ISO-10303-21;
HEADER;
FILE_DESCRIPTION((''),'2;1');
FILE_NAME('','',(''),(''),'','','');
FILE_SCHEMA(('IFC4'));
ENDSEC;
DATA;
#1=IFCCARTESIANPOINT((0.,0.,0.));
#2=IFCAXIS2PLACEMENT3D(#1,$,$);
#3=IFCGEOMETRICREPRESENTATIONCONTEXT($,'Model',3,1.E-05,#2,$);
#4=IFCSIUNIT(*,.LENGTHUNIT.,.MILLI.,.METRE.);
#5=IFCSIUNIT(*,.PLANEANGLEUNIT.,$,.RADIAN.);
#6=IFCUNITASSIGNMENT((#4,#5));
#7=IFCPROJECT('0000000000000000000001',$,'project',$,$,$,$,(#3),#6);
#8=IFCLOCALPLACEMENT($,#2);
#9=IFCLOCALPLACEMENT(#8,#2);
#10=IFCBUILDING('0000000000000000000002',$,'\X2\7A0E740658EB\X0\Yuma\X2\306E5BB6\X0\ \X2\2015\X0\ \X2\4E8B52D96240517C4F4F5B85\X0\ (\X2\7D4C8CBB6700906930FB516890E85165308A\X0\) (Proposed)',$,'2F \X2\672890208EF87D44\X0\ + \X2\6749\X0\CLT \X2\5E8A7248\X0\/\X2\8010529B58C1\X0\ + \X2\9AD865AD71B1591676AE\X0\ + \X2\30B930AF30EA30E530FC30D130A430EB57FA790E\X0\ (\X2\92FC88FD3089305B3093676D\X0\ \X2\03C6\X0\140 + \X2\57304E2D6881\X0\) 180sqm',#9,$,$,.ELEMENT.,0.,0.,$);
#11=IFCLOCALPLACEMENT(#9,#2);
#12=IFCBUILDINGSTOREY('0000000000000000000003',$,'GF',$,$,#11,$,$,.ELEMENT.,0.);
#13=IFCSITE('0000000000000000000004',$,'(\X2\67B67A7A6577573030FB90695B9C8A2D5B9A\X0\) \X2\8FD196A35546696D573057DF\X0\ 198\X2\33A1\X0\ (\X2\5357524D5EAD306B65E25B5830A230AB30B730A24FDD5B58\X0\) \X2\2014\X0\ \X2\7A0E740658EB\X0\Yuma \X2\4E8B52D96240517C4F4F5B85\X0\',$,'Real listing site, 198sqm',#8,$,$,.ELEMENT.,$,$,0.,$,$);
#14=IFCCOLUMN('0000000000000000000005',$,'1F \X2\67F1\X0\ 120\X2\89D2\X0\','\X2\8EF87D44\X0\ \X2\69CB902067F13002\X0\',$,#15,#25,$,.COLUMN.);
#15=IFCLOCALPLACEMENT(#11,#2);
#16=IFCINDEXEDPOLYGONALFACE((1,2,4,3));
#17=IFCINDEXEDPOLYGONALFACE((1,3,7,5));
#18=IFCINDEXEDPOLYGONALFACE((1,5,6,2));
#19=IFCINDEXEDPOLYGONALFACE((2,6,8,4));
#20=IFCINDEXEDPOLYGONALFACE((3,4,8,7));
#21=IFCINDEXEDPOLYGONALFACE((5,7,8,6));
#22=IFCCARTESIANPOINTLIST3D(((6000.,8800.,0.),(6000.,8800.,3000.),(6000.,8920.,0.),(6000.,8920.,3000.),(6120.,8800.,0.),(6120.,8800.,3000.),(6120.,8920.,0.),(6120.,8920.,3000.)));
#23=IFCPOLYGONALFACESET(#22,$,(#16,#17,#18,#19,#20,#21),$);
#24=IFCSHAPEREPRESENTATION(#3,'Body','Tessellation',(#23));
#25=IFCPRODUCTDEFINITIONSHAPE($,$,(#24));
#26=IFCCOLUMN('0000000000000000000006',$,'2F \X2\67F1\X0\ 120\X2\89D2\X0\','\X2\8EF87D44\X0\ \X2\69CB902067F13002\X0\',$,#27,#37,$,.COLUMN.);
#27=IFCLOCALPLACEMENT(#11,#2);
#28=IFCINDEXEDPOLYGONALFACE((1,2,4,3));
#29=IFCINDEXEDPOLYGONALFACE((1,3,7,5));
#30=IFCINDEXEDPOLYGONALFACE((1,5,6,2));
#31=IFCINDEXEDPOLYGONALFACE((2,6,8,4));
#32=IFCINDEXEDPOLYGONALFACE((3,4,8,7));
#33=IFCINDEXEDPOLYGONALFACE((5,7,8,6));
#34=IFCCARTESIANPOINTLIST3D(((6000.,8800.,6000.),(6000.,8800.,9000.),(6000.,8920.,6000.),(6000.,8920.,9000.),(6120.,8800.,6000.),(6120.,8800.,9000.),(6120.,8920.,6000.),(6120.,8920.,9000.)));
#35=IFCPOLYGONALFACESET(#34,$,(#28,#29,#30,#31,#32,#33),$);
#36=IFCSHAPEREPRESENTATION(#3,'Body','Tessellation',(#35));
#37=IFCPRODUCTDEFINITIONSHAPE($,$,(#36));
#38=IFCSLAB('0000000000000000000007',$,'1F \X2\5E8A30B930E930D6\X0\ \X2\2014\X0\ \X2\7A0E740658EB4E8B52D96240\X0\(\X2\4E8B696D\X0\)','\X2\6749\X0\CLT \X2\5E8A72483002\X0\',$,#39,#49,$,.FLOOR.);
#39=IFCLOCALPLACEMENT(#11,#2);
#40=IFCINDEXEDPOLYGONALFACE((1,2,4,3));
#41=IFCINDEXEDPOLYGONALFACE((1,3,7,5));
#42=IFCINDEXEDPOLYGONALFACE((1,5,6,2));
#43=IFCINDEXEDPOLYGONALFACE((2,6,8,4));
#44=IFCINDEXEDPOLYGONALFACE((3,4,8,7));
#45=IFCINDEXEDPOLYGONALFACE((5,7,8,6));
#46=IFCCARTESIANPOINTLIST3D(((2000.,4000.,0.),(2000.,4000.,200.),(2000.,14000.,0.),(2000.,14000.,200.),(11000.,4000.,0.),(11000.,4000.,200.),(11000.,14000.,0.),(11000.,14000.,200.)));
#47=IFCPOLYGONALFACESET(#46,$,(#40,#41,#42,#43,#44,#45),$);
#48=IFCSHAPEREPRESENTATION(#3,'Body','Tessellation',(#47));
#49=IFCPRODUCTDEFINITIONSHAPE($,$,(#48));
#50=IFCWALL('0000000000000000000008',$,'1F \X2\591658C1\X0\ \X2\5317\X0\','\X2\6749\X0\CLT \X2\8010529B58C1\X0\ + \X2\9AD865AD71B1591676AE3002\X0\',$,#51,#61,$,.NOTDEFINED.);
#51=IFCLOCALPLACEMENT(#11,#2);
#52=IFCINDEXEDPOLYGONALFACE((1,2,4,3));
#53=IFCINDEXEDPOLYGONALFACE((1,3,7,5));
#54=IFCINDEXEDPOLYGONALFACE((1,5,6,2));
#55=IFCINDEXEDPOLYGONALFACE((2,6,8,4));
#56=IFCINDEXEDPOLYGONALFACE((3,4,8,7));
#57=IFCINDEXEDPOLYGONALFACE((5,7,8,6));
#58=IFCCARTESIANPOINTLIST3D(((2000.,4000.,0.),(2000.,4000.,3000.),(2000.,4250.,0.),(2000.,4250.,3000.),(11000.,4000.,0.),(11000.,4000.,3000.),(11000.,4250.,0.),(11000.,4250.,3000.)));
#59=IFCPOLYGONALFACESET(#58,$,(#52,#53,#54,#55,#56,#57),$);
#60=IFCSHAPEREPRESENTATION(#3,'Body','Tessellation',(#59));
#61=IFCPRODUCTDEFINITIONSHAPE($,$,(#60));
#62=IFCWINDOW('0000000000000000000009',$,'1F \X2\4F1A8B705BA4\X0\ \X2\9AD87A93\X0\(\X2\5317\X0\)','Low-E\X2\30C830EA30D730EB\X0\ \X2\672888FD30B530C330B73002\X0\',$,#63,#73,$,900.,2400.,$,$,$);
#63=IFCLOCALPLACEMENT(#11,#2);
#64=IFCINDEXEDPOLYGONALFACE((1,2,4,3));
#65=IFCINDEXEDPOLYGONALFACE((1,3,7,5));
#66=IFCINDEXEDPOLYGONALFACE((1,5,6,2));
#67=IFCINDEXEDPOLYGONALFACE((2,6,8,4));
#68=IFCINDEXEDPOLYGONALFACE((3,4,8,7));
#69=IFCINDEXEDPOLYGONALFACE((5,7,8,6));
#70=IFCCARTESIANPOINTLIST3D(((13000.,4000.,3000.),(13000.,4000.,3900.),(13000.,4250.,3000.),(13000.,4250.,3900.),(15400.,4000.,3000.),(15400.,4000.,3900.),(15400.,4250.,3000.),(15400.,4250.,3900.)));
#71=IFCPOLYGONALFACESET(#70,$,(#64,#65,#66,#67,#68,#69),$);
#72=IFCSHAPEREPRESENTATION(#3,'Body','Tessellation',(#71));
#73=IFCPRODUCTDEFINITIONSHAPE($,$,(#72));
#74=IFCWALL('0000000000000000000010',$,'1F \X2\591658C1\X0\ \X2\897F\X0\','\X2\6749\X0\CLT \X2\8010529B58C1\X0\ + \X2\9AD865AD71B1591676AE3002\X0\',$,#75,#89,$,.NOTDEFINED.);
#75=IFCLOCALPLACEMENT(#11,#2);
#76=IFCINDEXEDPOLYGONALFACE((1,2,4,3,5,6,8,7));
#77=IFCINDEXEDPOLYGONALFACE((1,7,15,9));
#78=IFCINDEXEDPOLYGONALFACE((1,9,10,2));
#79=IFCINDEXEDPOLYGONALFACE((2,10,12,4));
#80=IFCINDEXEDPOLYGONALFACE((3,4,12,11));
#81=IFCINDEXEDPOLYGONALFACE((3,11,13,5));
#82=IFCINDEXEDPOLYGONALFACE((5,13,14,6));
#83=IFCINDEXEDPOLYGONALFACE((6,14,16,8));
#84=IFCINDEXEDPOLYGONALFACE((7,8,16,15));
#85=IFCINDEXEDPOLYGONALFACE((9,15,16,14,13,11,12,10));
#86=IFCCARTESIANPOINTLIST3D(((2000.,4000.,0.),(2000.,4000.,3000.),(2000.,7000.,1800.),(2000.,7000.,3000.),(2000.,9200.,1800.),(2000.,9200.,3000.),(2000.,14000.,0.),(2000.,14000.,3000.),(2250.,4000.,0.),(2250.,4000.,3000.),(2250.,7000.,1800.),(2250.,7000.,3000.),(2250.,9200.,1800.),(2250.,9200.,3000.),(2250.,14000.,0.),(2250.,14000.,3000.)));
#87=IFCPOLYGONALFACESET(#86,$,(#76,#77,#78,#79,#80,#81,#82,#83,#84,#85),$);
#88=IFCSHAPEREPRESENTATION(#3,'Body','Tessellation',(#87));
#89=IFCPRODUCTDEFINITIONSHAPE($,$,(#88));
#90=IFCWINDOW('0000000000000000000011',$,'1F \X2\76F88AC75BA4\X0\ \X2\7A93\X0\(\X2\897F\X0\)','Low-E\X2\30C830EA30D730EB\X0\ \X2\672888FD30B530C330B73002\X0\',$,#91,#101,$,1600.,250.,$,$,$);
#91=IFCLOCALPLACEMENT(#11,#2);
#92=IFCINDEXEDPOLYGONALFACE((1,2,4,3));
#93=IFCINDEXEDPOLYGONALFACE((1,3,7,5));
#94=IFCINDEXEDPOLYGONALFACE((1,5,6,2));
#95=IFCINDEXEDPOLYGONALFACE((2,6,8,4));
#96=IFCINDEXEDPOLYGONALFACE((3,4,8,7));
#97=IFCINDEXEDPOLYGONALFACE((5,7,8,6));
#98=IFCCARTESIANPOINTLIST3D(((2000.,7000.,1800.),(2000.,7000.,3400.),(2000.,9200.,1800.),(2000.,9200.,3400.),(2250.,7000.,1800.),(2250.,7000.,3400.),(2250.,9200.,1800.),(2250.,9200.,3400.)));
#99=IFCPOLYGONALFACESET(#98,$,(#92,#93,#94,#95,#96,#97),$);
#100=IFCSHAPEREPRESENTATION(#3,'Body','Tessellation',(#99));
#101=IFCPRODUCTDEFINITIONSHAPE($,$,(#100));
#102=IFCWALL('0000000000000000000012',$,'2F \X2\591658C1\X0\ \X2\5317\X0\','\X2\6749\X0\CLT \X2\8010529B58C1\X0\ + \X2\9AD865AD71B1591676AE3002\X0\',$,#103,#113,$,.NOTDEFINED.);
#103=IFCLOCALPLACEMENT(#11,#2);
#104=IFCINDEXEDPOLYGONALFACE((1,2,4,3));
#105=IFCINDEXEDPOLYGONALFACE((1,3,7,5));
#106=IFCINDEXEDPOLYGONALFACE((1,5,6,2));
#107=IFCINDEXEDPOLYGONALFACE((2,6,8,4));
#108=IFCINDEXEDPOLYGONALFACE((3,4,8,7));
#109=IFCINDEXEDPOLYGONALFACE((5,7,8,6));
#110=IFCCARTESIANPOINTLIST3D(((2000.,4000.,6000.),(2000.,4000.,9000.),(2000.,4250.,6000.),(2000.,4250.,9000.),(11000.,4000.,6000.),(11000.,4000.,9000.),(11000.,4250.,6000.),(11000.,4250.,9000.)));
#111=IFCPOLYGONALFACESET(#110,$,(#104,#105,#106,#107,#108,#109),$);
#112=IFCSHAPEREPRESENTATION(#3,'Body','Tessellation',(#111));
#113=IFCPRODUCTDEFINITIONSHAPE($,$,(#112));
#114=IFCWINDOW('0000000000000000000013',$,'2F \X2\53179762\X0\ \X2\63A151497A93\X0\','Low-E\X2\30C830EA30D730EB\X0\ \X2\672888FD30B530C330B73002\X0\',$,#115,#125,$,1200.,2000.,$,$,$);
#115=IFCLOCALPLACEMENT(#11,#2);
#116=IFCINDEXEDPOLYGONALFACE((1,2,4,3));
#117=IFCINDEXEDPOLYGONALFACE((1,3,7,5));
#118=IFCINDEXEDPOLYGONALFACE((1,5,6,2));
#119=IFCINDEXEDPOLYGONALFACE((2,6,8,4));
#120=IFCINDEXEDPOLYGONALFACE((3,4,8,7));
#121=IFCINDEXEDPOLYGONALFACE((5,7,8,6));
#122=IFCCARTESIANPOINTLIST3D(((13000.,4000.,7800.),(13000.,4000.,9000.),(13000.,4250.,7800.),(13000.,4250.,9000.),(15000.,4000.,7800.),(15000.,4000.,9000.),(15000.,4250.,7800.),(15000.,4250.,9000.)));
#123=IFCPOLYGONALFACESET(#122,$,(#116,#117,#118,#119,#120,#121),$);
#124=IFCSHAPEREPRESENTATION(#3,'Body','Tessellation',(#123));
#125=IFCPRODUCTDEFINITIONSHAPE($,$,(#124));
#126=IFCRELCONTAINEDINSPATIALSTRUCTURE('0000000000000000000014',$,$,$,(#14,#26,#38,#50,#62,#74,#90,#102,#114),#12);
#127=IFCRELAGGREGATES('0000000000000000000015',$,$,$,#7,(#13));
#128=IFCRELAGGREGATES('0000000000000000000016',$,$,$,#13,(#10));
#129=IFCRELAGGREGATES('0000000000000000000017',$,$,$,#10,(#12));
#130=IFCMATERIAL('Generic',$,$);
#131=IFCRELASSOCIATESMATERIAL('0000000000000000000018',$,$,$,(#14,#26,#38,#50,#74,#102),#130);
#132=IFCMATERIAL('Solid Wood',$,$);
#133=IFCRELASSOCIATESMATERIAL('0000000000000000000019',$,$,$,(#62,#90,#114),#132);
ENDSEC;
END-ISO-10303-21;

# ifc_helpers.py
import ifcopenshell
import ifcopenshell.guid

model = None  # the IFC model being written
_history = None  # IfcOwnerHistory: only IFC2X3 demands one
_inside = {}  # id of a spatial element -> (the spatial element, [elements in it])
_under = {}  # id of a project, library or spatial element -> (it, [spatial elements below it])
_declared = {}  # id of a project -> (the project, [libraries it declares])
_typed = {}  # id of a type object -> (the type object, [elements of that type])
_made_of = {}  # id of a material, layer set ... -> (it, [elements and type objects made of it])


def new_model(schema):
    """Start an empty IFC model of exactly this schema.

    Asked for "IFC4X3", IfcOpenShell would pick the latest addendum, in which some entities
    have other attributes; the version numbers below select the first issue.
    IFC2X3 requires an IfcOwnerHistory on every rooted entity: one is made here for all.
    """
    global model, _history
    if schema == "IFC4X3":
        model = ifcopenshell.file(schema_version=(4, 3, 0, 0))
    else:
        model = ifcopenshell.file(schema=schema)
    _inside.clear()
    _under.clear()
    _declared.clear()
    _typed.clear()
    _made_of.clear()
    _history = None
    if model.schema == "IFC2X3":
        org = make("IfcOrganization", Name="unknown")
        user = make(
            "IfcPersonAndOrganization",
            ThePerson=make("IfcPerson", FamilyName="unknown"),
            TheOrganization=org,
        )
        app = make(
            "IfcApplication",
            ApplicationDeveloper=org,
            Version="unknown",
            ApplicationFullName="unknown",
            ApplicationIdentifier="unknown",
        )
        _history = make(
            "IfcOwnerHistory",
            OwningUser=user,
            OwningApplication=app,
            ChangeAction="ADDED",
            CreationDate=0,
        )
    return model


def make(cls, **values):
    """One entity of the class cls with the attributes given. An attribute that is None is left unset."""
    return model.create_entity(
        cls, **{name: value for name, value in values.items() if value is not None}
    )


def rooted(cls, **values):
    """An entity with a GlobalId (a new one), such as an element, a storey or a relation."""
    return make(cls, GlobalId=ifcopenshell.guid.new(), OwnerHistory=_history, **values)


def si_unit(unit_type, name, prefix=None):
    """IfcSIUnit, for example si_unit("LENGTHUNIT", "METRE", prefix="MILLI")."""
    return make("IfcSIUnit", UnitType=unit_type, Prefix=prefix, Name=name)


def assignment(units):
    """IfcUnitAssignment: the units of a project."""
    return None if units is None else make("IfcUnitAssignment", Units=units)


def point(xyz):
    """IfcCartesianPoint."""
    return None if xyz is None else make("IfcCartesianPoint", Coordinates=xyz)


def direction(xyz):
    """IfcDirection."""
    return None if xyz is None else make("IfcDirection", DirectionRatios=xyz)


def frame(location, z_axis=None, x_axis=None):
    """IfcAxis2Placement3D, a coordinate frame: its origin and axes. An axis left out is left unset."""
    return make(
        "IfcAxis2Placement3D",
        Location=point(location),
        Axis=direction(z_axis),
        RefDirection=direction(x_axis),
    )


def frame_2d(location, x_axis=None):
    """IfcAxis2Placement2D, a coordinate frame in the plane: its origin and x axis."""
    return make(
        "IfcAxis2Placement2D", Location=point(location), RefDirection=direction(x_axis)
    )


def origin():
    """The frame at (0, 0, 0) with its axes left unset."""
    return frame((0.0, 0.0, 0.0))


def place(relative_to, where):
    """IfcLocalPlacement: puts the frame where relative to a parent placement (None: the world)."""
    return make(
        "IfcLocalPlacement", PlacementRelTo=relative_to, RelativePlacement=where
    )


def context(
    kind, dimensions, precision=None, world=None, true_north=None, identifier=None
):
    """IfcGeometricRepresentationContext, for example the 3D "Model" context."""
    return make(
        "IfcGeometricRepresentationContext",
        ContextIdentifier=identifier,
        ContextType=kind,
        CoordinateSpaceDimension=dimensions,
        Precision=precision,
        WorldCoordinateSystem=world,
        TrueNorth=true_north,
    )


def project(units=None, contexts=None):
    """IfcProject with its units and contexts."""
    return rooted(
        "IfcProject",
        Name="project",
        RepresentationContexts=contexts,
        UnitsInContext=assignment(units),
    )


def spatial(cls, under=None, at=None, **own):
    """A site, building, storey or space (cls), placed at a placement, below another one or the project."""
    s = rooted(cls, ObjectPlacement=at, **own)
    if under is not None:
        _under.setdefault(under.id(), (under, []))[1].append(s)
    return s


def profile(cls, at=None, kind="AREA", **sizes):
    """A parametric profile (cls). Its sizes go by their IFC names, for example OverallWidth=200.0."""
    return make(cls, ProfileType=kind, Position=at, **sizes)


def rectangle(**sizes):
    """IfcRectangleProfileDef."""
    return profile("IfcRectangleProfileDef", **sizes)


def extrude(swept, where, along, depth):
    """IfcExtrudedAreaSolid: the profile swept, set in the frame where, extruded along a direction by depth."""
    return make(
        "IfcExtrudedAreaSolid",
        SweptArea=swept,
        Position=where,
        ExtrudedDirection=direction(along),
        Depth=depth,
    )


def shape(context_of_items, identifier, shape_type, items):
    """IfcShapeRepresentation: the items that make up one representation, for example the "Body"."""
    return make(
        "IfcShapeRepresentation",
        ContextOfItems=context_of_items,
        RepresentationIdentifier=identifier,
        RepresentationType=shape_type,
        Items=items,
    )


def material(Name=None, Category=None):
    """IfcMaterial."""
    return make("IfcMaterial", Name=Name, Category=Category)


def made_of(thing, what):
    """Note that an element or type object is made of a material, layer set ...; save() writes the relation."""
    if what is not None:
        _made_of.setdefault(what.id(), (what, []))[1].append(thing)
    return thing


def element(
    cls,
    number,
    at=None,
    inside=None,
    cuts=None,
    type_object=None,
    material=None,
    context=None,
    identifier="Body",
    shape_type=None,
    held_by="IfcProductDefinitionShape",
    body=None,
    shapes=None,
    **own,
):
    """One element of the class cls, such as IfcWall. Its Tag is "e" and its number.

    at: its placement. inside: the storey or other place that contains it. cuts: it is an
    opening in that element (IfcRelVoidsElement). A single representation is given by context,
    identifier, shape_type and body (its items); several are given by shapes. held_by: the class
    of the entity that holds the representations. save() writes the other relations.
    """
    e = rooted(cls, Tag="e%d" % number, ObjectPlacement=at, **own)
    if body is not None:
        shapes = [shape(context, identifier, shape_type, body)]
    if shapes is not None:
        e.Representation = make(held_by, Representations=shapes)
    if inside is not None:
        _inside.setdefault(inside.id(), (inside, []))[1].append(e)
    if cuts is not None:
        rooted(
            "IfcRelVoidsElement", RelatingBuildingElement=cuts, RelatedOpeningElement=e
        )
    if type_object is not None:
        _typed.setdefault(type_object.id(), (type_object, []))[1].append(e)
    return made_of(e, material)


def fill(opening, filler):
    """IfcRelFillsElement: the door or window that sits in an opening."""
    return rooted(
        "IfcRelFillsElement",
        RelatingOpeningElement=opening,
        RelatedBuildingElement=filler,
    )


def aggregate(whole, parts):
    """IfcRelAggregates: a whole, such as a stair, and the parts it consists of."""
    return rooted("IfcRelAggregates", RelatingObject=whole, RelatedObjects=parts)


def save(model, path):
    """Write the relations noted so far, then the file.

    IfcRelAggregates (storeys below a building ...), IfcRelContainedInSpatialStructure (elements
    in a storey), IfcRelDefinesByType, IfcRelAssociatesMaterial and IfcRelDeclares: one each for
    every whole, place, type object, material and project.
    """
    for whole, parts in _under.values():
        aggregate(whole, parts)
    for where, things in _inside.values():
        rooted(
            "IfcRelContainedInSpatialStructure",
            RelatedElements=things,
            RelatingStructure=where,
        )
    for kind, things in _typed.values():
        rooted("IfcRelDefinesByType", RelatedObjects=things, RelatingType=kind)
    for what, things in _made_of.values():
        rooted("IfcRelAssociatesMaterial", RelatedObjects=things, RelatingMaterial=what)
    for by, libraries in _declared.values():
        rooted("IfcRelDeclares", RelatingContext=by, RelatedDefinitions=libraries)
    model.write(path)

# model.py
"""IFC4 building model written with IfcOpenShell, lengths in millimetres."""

from ifc_helpers import new_model, si_unit, frame, frame_2d, origin, place, context, project, spatial, rectangle, extrude, material, element, fill, save


model = new_model("IFC4")

# Units and contexts
model_context = context("Model", 3, precision=1e-05, world=origin())
ifc_project = project(units=[si_unit("LENGTHUNIT", "METRE", prefix="MILLI"), si_unit("PLANEANGLEUNIT", "RADIAN")], contexts=[model_context])

# Site, building, storey
site_placement = place(None, origin())
site = spatial("IfcSite", under=ifc_project, at=site_placement, Name="(架空敷地・適宜設定) 近隣商業地域 198㎡ (南前庭に既存アカシア保存) — 税理士Yuma 事務所兼住宅", ObjectType="Real listing site, 198sqm", CompositionType="ELEMENT", RefElevation=0.0)
building_placement = place(site_placement, origin())
building = spatial("IfcBuilding", under=site, at=building_placement, Name="税理士Yumaの家 ― 事務所兼住宅 (経費最適・全部入り) (Proposed)", ObjectType="2F 木造軸組 + 杉CLT 床版/耐力壁 + 高断熱外皮 + スクリューパイル基礎 (鋼製らせん杭 φ140 + 地中梁) 180sqm", CompositionType="ELEMENT", ElevationOfRefHeight=0.0, ElevationOfTerrain=0.0)
storey_placement = place(building_placement, origin())
storey = spatial("IfcBuildingStorey", under=building, at=storey_placement, Name="GF", CompositionType="ELEMENT", Elevation=0.0)

# Columns
ifc_material_1 = material(Name="Generic")
column_1_placement = place(storey_placement, frame((3000.0, 4400.0, 0.0)))
element("IfcColumn", 1, at=column_1_placement, inside=storey, material=ifc_material_1, Name="1F 柱 120角", Description="軸組 構造柱。", PredefinedType="COLUMN", context=model_context, shape_type="SweptSolid", body=[
    extrude(rectangle(XDim=120.0, YDim=120.0, at=frame_2d((60.0, 60.0))), frame((3000.0, 4400.0, 0.0)), (0.0, 0.0, 1.0), 3000.0),
])
column_2_placement = place(storey_placement, frame((3000.0, 4400.0, 3000.0)))
element("IfcColumn", 2, at=column_2_placement, inside=storey, material=ifc_material_1, Name="2F 柱 120角", Description="軸組 構造柱。", PredefinedType="COLUMN", context=model_context, shape_type="SweptSolid", body=[
    extrude(rectangle(XDim=120.0, YDim=120.0, at=frame_2d((60.0, 60.0))), frame((3000.0, 4400.0, 3000.0)), (0.0, 0.0, 1.0), 3000.0),
])

# Slab
slab_1_placement = place(storey_placement, frame((1000.0, 2000.0, 0.0)))
element("IfcSlab", 3, at=slab_1_placement, inside=storey, material=ifc_material_1, Name="1F 床スラブ — 税理士事務所(事業)", Description="杉CLT 床版。", PredefinedType="FLOOR", context=model_context, shape_type="SweptSolid", body=[
    extrude(rectangle(XDim=9000.0, YDim=10000.0, at=frame_2d((4500.0, 5000.0))), frame((1000.0, 2000.0, 0.0)), (0.0, 0.0, 1.0), 200.0),
])

# Walls, openings, windows
wall_1_placement = place(storey_placement, frame((1000.0, 2000.0, 0.0)))
wall_1 = element("IfcWall", 4, at=wall_1_placement, inside=storey, material=ifc_material_1, Name="1F 外壁 北", Description="杉CLT 耐力壁 + 高断熱外皮。", PredefinedType="NOTDEFINED", context=model_context, shape_type="SweptSolid", body=[
    extrude(rectangle(XDim=9000.0, YDim=250.0, at=frame_2d((4500.0, 125.0))), frame((1000.0, 2000.0, 0.0)), (0.0, 0.0, 1.0), 3000.0),
])
opening_1_placement = place(storey_placement, frame((6500.0, 2000.0, 1500.0)))
opening_1 = element("IfcOpeningElement", 5, at=opening_1_placement, cuts=wall_1, PredefinedType="NOTDEFINED", context=model_context, shape_type="SweptSolid", body=[
    extrude(rectangle(XDim=2400.0, YDim=250.0, at=frame_2d((1200.0, 125.0))), frame((6500.0, 2000.0, 1500.0)), (0.0, 0.0, 1.0), 900.0),
])
ifc_material_2 = material(Name="Solid Wood")
window_1_placement = place(storey_placement, frame((6500.0, 2000.0, 1500.0)))
window_1 = element("IfcWindow", 6, at=window_1_placement, inside=storey, material=ifc_material_2, Name="1F 会議室 高窓(北)", Description="Low-Eトリプル 木製サッシ。", OverallHeight=900.0, OverallWidth=2400.0, context=model_context, shape_type="SweptSolid", body=[
    extrude(rectangle(XDim=2400.0, YDim=250.0, at=frame_2d((1200.0, 125.0))), frame((6500.0, 2000.0, 1500.0)), (0.0, 0.0, 1.0), 900.0),
])
fill(opening_1, window_1)
wall_2_placement = place(storey_placement, frame((1000.0, 2000.0, 0.0)))
wall_2 = element("IfcWall", 7, at=wall_2_placement, inside=storey, material=ifc_material_1, Name="1F 外壁 西", Description="杉CLT 耐力壁 + 高断熱外皮。", PredefinedType="NOTDEFINED", context=model_context, shape_type="SweptSolid", body=[
    extrude(rectangle(XDim=250.0, YDim=10000.0, at=frame_2d((125.0, 5000.0))), frame((1000.0, 2000.0, 0.0)), (0.0, 0.0, 1.0), 3000.0),
])
opening_2_placement = place(storey_placement, frame((1000.0, 3500.0, 900.0)))
opening_2 = element("IfcOpeningElement", 8, at=opening_2_placement, cuts=wall_2, PredefinedType="NOTDEFINED", context=model_context, shape_type="SweptSolid", body=[
    extrude(rectangle(XDim=250.0, YDim=2200.0, at=frame_2d((125.0, 1100.0))), frame((1000.0, 3500.0, 900.0)), (0.0, 0.0, 1.0), 1600.0),
])
window_2_placement = place(storey_placement, frame((1000.0, 3500.0, 900.0)))
window_2 = element("IfcWindow", 9, at=window_2_placement, inside=storey, material=ifc_material_2, Name="1F 相談室 窓(西)", Description="Low-Eトリプル 木製サッシ。", OverallHeight=1600.0, OverallWidth=250.0, context=model_context, shape_type="SweptSolid", body=[
    extrude(rectangle(XDim=250.0, YDim=2200.0, at=frame_2d((125.0, 1100.0))), frame((1000.0, 3500.0, 900.0)), (0.0, 0.0, 1.0), 1600.0),
])
fill(opening_2, window_2)

# Wall, opening, window
wall_3_placement = place(storey_placement, frame((1000.0, 2000.0, 3000.0)))
wall_3 = element("IfcWall", 10, at=wall_3_placement, inside=storey, material=ifc_material_1, Name="2F 外壁 北", Description="杉CLT 耐力壁 + 高断熱外皮。", PredefinedType="NOTDEFINED", context=model_context, shape_type="SweptSolid", body=[
    extrude(rectangle(XDim=9000.0, YDim=250.0, at=frame_2d((4500.0, 125.0))), frame((1000.0, 2000.0, 3000.0)), (0.0, 0.0, 1.0), 3000.0),
])
opening_3_placement = place(storey_placement, frame((6500.0, 2000.0, 3900.0)))
opening_3 = element("IfcOpeningElement", 11, at=opening_3_placement, cuts=wall_3, PredefinedType="NOTDEFINED", context=model_context, shape_type="SweptSolid", body=[
    extrude(rectangle(XDim=2000.0, YDim=250.0, at=frame_2d((1000.0, 125.0))), frame((6500.0, 2000.0, 3900.0)), (0.0, 0.0, 1.0), 1200.0),
])
window_3_placement = place(storey_placement, frame((6500.0, 2000.0, 3900.0)))
window_3 = element("IfcWindow", 12, at=window_3_placement, inside=storey, material=ifc_material_2, Name="2F 北面 採光窓", Description="Low-Eトリプル 木製サッシ。", OverallHeight=1200.0, OverallWidth=2000.0, context=model_context, shape_type="SweptSolid", body=[
    extrude(rectangle(XDim=2000.0, YDim=250.0, at=frame_2d((1000.0, 125.0))), frame((6500.0, 2000.0, 3900.0)), (0.0, 0.0, 1.0), 1200.0),
])
fill(opening_3, window_3)

save(model, "model.ifc")
